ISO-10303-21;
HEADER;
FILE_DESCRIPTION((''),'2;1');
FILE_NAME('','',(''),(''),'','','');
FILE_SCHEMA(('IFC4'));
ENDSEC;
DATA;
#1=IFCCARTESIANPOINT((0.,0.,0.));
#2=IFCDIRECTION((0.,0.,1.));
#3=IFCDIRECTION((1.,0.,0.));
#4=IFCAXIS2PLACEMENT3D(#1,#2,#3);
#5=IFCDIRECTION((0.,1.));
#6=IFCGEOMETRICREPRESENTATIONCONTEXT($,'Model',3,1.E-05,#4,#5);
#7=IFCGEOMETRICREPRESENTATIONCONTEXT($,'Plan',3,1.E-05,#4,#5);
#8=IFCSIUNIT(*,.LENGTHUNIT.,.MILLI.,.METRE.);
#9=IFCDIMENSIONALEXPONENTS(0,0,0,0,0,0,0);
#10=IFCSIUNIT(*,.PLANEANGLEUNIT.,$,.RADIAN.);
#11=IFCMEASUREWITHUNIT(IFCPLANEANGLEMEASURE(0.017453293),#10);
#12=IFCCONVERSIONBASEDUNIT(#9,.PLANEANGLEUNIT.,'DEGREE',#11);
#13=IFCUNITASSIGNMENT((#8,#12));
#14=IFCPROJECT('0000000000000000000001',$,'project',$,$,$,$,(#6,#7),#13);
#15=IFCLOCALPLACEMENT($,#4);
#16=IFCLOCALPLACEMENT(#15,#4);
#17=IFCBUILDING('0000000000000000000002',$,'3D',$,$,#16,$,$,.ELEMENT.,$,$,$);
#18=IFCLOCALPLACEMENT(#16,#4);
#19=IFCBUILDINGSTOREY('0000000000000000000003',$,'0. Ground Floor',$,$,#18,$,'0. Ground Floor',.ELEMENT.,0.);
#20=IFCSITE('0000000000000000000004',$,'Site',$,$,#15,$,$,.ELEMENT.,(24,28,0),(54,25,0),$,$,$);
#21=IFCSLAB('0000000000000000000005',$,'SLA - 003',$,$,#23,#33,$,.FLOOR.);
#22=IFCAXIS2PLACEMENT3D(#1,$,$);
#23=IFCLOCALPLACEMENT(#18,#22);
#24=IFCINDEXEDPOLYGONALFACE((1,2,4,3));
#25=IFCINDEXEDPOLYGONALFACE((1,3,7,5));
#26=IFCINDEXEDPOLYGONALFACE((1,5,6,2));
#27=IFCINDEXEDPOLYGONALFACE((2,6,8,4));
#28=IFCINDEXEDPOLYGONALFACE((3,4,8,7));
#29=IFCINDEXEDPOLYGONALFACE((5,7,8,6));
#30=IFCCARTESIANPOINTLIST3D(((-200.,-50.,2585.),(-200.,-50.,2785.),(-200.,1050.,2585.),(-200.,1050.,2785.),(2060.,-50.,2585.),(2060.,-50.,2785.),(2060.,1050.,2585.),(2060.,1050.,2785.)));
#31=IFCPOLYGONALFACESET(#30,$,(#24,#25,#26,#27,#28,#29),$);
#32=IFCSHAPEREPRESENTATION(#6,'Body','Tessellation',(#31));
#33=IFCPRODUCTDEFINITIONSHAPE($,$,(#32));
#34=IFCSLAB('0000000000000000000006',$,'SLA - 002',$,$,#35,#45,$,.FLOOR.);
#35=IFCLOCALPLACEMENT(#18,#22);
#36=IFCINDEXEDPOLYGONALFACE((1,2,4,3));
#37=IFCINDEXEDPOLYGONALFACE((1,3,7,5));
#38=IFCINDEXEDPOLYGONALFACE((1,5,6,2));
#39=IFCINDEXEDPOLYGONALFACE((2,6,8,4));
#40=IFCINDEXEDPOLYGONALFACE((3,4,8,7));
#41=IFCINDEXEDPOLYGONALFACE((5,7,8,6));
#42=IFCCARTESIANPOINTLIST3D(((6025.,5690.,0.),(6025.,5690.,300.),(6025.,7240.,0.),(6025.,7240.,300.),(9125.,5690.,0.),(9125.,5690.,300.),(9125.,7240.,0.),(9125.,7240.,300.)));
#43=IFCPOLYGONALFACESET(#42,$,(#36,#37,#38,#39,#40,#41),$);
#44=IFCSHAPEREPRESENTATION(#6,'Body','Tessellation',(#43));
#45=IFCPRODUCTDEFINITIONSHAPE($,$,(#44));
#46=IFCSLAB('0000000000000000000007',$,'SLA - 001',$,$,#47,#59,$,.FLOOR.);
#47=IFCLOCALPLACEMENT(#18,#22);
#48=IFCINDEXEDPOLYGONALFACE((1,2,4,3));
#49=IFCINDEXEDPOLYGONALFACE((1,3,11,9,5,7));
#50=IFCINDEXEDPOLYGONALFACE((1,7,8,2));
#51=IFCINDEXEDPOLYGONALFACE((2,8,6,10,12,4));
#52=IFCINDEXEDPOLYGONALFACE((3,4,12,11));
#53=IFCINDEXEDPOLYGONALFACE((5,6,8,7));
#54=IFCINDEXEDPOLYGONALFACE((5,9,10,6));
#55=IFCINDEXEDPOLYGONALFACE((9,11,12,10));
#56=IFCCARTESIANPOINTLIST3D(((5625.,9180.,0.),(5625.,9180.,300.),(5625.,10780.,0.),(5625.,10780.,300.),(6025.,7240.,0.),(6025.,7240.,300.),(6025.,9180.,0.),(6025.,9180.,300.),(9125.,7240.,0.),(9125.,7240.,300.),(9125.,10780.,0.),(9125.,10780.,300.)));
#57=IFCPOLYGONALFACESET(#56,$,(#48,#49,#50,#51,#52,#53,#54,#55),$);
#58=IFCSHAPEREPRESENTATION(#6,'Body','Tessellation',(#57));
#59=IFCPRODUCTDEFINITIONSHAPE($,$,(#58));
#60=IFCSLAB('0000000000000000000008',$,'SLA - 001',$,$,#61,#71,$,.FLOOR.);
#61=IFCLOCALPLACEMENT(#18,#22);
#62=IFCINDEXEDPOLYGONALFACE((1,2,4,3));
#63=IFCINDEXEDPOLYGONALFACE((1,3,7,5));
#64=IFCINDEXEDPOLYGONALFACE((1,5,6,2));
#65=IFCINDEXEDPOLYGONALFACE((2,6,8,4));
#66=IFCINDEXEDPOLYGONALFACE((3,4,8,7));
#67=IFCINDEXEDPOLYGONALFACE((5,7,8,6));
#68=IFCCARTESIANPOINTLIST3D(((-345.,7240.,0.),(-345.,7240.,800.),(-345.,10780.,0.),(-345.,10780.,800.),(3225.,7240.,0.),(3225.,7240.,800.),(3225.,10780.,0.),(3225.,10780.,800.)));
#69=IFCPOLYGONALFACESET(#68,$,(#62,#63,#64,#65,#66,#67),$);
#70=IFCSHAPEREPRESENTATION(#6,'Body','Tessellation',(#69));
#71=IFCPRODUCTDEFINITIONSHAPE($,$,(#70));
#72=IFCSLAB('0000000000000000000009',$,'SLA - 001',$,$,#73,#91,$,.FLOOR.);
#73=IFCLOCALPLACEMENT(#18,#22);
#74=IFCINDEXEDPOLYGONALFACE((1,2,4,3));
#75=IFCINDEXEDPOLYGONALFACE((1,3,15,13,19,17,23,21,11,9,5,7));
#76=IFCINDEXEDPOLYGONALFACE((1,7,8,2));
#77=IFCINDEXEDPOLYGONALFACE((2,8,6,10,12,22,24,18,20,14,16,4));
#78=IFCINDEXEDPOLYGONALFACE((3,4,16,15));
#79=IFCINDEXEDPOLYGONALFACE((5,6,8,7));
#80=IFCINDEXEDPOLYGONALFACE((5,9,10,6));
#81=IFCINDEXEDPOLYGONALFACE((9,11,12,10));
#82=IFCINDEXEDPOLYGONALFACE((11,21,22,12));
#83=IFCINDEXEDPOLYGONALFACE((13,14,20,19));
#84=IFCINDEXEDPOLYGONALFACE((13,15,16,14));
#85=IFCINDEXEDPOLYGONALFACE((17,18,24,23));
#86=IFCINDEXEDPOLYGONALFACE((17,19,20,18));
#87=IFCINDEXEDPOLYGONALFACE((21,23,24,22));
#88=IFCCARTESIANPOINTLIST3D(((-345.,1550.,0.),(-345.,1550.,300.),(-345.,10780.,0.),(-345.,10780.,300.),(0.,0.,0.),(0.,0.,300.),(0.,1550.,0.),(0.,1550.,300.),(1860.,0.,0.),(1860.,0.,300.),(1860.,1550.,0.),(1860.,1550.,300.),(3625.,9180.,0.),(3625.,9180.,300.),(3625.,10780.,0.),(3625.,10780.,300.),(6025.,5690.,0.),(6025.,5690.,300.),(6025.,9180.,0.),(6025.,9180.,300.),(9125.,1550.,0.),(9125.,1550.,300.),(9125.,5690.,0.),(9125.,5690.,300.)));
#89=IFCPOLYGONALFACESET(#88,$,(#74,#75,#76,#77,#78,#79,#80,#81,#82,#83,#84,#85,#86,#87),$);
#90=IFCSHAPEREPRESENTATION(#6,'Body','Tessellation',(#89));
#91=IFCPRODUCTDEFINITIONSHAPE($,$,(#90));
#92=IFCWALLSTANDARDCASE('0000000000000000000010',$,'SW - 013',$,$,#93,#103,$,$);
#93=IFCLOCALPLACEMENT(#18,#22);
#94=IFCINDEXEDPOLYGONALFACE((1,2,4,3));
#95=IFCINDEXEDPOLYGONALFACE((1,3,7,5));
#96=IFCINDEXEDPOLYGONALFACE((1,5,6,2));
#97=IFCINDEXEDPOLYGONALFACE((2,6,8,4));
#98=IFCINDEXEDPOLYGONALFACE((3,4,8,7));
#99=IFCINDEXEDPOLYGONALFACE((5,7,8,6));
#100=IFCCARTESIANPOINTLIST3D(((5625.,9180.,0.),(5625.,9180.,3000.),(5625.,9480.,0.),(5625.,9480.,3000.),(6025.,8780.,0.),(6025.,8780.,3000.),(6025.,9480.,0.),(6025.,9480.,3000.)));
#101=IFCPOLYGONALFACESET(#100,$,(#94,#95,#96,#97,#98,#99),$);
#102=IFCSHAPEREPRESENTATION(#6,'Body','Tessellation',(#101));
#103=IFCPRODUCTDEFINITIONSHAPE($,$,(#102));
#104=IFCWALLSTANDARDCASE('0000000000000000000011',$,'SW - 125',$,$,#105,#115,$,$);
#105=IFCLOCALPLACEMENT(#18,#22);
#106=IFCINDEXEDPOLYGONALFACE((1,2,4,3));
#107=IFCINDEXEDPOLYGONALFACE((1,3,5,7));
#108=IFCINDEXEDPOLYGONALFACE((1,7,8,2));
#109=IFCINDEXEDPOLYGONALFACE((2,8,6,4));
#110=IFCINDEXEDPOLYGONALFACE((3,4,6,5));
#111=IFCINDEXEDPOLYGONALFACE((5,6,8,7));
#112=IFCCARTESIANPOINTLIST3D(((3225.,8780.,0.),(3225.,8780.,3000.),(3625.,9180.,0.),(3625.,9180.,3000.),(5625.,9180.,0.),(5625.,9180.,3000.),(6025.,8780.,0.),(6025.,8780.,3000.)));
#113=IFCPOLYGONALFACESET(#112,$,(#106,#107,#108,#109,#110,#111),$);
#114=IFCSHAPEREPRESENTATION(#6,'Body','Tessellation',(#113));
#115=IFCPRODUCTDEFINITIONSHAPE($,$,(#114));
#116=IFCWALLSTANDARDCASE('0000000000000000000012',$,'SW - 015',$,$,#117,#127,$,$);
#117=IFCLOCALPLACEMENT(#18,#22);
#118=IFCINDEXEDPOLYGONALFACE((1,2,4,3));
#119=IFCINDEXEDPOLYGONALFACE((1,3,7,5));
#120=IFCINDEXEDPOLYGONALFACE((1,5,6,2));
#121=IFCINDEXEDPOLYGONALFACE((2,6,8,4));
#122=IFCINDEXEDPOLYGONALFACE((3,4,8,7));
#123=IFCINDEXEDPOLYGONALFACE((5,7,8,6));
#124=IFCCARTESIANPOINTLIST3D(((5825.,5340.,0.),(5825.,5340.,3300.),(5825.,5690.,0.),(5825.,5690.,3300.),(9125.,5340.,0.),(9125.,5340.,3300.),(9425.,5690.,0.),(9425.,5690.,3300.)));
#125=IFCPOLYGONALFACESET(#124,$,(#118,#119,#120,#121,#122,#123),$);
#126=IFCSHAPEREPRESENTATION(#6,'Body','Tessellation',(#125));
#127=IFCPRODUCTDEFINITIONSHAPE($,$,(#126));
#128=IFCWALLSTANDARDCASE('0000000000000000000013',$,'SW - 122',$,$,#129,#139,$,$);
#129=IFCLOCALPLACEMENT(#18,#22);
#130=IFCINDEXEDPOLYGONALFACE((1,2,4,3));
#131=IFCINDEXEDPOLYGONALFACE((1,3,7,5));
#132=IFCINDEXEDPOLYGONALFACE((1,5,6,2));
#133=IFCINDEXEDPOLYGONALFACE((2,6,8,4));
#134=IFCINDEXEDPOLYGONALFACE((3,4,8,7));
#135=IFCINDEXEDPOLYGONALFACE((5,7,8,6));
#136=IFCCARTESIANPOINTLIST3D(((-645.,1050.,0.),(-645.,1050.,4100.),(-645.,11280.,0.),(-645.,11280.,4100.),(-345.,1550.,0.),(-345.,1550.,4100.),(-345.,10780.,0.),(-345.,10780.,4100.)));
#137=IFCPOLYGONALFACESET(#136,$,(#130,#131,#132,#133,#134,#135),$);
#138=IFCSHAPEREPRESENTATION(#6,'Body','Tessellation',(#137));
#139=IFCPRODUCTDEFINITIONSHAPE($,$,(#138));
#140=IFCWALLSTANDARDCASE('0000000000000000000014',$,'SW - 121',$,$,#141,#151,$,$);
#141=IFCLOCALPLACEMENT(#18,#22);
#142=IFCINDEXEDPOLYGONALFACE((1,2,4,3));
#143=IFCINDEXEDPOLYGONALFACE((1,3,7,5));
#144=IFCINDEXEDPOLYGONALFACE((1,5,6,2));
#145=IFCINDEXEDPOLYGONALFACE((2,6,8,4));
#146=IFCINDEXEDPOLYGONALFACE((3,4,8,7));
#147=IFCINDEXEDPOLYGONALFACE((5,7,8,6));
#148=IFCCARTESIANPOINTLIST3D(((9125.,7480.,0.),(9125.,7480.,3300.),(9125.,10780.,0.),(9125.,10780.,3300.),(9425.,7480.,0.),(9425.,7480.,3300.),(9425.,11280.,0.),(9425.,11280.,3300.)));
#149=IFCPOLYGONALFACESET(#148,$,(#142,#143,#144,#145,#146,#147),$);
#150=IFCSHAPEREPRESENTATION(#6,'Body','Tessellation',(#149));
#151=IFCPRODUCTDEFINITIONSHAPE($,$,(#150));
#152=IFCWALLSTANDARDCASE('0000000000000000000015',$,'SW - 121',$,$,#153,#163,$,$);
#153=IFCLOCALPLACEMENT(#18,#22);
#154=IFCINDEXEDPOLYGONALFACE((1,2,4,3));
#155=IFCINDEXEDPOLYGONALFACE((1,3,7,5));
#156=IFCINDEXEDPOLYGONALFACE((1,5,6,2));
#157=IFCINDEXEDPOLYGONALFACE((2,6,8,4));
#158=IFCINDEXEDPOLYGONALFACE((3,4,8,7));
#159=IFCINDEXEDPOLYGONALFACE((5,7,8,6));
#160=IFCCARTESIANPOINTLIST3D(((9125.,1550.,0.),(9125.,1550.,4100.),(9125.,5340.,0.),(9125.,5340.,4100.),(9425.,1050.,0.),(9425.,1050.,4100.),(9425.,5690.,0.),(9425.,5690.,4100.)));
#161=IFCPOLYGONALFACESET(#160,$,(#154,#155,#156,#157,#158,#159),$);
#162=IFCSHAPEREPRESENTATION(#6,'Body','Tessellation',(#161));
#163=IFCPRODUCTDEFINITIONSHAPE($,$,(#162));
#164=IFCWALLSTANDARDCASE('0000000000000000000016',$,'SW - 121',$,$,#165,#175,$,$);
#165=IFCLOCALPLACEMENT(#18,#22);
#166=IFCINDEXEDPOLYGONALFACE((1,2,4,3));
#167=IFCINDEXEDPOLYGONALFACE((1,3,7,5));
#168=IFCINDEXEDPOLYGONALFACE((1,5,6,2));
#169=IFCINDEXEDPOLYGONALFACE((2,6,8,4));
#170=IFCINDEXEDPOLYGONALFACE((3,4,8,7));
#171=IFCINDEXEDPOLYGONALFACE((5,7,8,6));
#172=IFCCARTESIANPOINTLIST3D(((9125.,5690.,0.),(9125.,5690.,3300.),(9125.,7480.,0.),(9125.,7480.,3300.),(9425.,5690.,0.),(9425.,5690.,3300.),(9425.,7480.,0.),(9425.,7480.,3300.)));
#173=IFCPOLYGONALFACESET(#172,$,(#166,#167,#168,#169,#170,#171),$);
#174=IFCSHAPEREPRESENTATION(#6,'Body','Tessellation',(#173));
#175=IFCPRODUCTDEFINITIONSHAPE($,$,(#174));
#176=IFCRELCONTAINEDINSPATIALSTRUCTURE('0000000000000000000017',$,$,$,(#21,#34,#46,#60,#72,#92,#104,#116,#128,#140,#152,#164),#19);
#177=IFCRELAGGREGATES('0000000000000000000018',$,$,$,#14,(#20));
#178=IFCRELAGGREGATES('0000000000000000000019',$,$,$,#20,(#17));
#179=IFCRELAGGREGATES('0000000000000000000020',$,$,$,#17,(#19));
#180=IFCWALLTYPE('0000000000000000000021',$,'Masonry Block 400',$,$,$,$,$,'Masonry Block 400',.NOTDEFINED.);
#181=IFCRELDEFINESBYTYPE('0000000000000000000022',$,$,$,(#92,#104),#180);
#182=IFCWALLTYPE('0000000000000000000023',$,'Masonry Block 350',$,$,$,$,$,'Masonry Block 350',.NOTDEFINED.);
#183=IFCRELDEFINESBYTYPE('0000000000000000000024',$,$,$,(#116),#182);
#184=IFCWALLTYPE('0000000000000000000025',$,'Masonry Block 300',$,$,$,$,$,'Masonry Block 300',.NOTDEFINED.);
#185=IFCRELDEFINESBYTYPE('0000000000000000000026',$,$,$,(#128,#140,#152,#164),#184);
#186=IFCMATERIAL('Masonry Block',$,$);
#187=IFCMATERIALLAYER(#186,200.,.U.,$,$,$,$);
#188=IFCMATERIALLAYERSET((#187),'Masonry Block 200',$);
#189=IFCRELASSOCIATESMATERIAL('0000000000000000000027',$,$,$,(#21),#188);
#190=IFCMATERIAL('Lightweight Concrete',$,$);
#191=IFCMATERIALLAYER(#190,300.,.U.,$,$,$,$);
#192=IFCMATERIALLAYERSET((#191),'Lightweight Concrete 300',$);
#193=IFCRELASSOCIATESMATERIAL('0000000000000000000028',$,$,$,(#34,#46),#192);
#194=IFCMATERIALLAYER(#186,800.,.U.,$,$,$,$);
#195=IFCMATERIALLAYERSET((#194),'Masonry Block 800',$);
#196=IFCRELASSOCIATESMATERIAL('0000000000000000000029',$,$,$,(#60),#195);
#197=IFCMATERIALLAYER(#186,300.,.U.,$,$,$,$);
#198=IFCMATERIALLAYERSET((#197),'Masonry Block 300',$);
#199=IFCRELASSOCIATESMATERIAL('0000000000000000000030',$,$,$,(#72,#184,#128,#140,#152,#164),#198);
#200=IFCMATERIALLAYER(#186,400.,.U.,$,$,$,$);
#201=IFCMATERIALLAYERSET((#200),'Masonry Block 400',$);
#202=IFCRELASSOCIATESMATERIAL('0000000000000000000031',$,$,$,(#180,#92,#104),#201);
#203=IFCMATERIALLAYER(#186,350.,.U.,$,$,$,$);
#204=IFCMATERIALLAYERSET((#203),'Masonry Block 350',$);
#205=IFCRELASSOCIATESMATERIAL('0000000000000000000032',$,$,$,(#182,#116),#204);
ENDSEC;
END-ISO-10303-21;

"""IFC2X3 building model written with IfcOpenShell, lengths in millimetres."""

from ifc_helpers import new_model, entity, si_unit, converted_unit, direction, frame, origin_with_axes, place, context, project, spatial, polyline, outline, extrude, material, layer, layer_set, layer_usage, type_object, element, save


model = new_model("IFC2X3")

# Units and contexts
model_context = context("Model", 3, precision=1e-05, world=origin_with_axes(), true_north=direction((0.0, 1.0)))
plan_context = context("Plan", 3, precision=1e-05, world=origin_with_axes(), true_north=direction((0.0, 1.0)))
ifc_project = project(units=[si_unit("LENGTHUNIT", "METRE", prefix="MILLI"), converted_unit("PLANEANGLEUNIT", "DEGREE", entity("IfcPlaneAngleMeasure", 0.017453293), si_unit("PLANEANGLEUNIT", "RADIAN"), dimensions=[0, 0, 0, 0, 0, 0, 0])], contexts=[model_context, plan_context])

# Site, building, storey
site_placement = place(None, origin_with_axes())
site = spatial("IfcSite", under=ifc_project, at=site_placement, Name="Site", CompositionType="ELEMENT", RefLatitude=(24, 28, 0), RefLongitude=(54, 25, 0))
building_placement = place(site_placement, origin_with_axes())
building = spatial("IfcBuilding", under=site, at=building_placement, Name="3D", CompositionType="ELEMENT")
storey_placement = place(building_placement, origin_with_axes())
storey = spatial("IfcBuildingStorey", under=building, at=storey_placement, Name="0. Ground Floor", LongName="0. Ground Floor", CompositionType="ELEMENT", Elevation=0.0)

# Slabs
ifc_material_1 = material(Name="Masonry Block")
ifc_layer_1 = layer(ifc_material_1, 200.0, ventilated="UNKNOWN")
ifc_layer_set_1 = layer_set([ifc_layer_1], Name="Masonry Block 200")
ifc_layer_usage_1 = layer_usage(ifc_layer_set_1, "AXIS3", "NEGATIVE", 200.0)
slab_1_placement = place(storey_placement, frame((-200.0, 1050.0, 2585.0), z_axis=(0.0, 0.0, 1.0), x_axis=(1.0, 0.0, 0.0)))
element("IfcSlab", 1, at=slab_1_placement, inside=storey, material=ifc_layer_usage_1, Name="SLA - 003", PredefinedType="FLOOR", context=model_context, shape_type="SweptSolid", body=[
    extrude(outline(polyline([(0.0, 0.0), (2260.0, 0.0), (2260.0, -1100.0), (0.0, -1100.0), (0.0, 0.0)])), origin_with_axes(), (0.0, 0.0, 1.0), 200.0),
])
ifc_material_2 = material(Name="Lightweight Concrete")
ifc_layer_2 = layer(ifc_material_2, 300.0, ventilated="UNKNOWN")
ifc_layer_set_2 = layer_set([ifc_layer_2], Name="Lightweight Concrete 300")
ifc_layer_usage_2 = layer_usage(ifc_layer_set_2, "AXIS3", "NEGATIVE", 300.0)
slab_2_placement = place(storey_placement, frame((9125.0, 7240.0, 0.0), z_axis=(0.0, 0.0, 1.0), x_axis=(-1.0, 0.0, 0.0)))
element("IfcSlab", 2, at=slab_2_placement, inside=storey, material=ifc_layer_usage_2, Name="SLA - 002", PredefinedType="FLOOR", context=model_context, shape_type="SweptSolid", body=[
    extrude(outline(polyline([(0.0, 0.0), (3100.0, 0.0), (3100.0, 1550.0), (0.0, 1550.0), (0.0, 0.0)])), origin_with_axes(), (0.0, 0.0, 1.0), 300.0),
])
ifc_layer_usage_3 = layer_usage(ifc_layer_set_2, "AXIS3", "NEGATIVE", 300.0)
slab_3_placement = place(storey_placement, frame((5625.0, 9180.0, 0.0), z_axis=(0.0, 0.0, 1.0), x_axis=(1.0, 0.0, 0.0)))
element("IfcSlab", 3, at=slab_3_placement, inside=storey, material=ifc_layer_usage_3, Name="SLA - 001", PredefinedType="FLOOR", context=model_context, shape_type="SweptSolid", body=[
    extrude(outline(polyline([(0.0, 0.0), (400.0, 0.0), (400.0, -1940.0), (3500.0, -1940.0), (3500.0, 1600.0), (0.0, 1600.0), (0.0, 0.0)])), origin_with_axes(), (0.0, 0.0, 1.0), 300.0),
])
ifc_layer_3 = layer(ifc_material_1, 800.0, ventilated="UNKNOWN")
ifc_layer_set_3 = layer_set([ifc_layer_3], Name="Masonry Block 800")
ifc_layer_usage_4 = layer_usage(ifc_layer_set_3, "AXIS3", "NEGATIVE", 800.0)
slab_4_placement = place(storey_placement, frame((-345.0, 10780.0, 0.0), z_axis=(0.0, 0.0, 1.0), x_axis=(1.0, 0.0, 0.0)))
element("IfcSlab", 4, at=slab_4_placement, inside=storey, material=ifc_layer_usage_4, Name="SLA - 001", PredefinedType="FLOOR", context=model_context, shape_type="SweptSolid", body=[
    extrude(outline(polyline([(0.0, 0.0), (3570.0, 0.0), (3570.0, -3540.0), (0.0, -3540.0), (0.0, 0.0)])), origin_with_axes(), (0.0, 0.0, 1.0), 800.0),
])
ifc_layer_4 = layer(ifc_material_1, 300.0, ventilated="UNKNOWN")
ifc_layer_set_4 = layer_set([ifc_layer_4], Name="Masonry Block 300")
ifc_layer_usage_5 = layer_usage(ifc_layer_set_4, "AXIS3", "NEGATIVE", 300.0)
slab_5_placement = place(storey_placement, frame((-345.0, 10780.0, 0.0), z_axis=(0.0, 0.0, 1.0), x_axis=(0.0, -1.0, 0.0)))
element("IfcSlab", 5, at=slab_5_placement, inside=storey, material=ifc_layer_usage_5, Name="SLA - 001", PredefinedType="FLOOR", context=model_context, shape_type="SweptSolid", body=[
    extrude(outline(polyline([(0.0, 0.0), (9230.0, 0.0), (9230.0, 345.0), (10780.0, 345.0), (10780.0, 2205.0), (9230.0, 2205.0), (9230.0, 9470.0), (5090.0, 9470.0), (5090.0, 6370.0), (1600.0, 6370.0), (1600.0, 3970.0), (0.0, 3970.0), (0.0, 0.0)])), origin_with_axes(), (0.0, 0.0, 1.0), 300.0),
])

# Walls
ifc_layer_5 = layer(ifc_material_1, 400.0, ventilated="UNKNOWN")
ifc_layer_set_5 = layer_set([ifc_layer_5], Name="Masonry Block 400")
wall_type_1 = type_object("IfcWallType", Name="Masonry Block 400", ElementType="Masonry Block 400", PredefinedType="NOTDEFINED", material=ifc_layer_set_5)
ifc_layer_usage_6 = layer_usage(ifc_layer_set_5, "AXIS2", "POSITIVE", 0.0)
wall_1_placement = place(storey_placement, frame((6025.0, 8780.0, 0.0), z_axis=(0.0, 0.0, 1.0), x_axis=(0.0, 1.0, 0.0)))
element("IfcWallStandardCase", 6, at=wall_1_placement, inside=storey, type_object=wall_type_1, material=ifc_layer_usage_6, Name="SW - 013", context=model_context, shape_type="SweptSolid", body=[
    extrude(outline(polyline([(0.0, 0.0), (700.0, 0.0), (700.0, 400.0), (400.0, 400.0), (0.0, 0.0)])), origin_with_axes(), (0.0, 0.0, 1.0), 3000.0),
])
ifc_layer_usage_7 = layer_usage(ifc_layer_set_5, "AXIS2", "POSITIVE", 0.0)
wall_2_placement = place(storey_placement, frame((3225.0, 8780.0, 0.0), z_axis=(0.0, 0.0, 1.0), x_axis=(1.0, 0.0, 0.0)))
element("IfcWallStandardCase", 7, at=wall_2_placement, inside=storey, type_object=wall_type_1, material=ifc_layer_usage_7, Name="SW - 125", context=model_context, shape_type="SweptSolid", body=[
    extrude(outline(polyline([(0.0, 0.0), (2800.0, 0.0), (2400.0, 400.0), (400.0, 400.0), (0.0, 0.0)])), origin_with_axes(), (0.0, 0.0, 1.0), 3000.0),
])
ifc_layer_6 = layer(ifc_material_1, 350.0, ventilated="UNKNOWN")
ifc_layer_set_6 = layer_set([ifc_layer_6], Name="Masonry Block 350")
ifc_layer_usage_8 = layer_usage(ifc_layer_set_6, "AXIS2", "POSITIVE", 0.0)
wall_type_2 = type_object("IfcWallType", Name="Masonry Block 350", ElementType="Masonry Block 350", PredefinedType="NOTDEFINED", material=ifc_layer_set_6)
wall_3_placement = place(storey_placement, frame((5825.0, 5340.0, 0.0), z_axis=(0.0, 0.0, 1.0), x_axis=(1.0, 0.0, 0.0)))
element("IfcWallStandardCase", 8, at=wall_3_placement, inside=storey, type_object=wall_type_2, material=ifc_layer_usage_8, Name="SW - 015", context=model_context, shape_type="SweptSolid", body=[
    extrude(outline(polyline([(0.0, 0.0), (3300.0, 0.0), (3600.0, 350.0), (0.0, 350.0), (0.0, 0.0)])), origin_with_axes(), (0.0, 0.0, 1.0), 3300.0),
])
ifc_layer_usage_9 = layer_usage(ifc_layer_set_4, "AXIS2", "POSITIVE", 0.0)
wall_type_3 = type_object("IfcWallType", Name="Masonry Block 300", ElementType="Masonry Block 300", PredefinedType="NOTDEFINED", material=ifc_layer_set_4)
wall_4_placement = place(storey_placement, frame((-645.0, 11280.0, 0.0), z_axis=(0.0, 0.0, 1.0), x_axis=(0.0, -1.0, 0.0)))
element("IfcWallStandardCase", 9, at=wall_4_placement, inside=storey, type_object=wall_type_3, material=ifc_layer_usage_9, Name="SW - 122", context=model_context, shape_type="SweptSolid", body=[
    extrude(outline(polyline([(0.0, 0.0), (10230.0, 0.0), (9730.0, 300.0), (500.0, 300.0), (0.0, 0.0)])), origin_with_axes(), (0.0, 0.0, 1.0), 4100.0),
])
ifc_layer_usage_10 = layer_usage(ifc_layer_set_4, "AXIS2", "NEGATIVE", 0.0)
wall_5_placement = place(storey_placement, frame((9425.0, 11280.0, 0.0), z_axis=(0.0, 0.0, 1.0), x_axis=(0.0, -1.0, 0.0)))
element("IfcWallStandardCase", 10, at=wall_5_placement, inside=storey, type_object=wall_type_3, material=ifc_layer_usage_10, Name="SW - 121", context=model_context, shape_type="SweptSolid", body=[
    extrude(outline(polyline([(500.0, -300.0), (3800.0, -300.0), (3800.0, 0.0), (0.0, 0.0), (500.0, -300.0)])), origin_with_axes(), (0.0, 0.0, 1.0), 3300.0),
])
ifc_layer_usage_11 = layer_usage(ifc_layer_set_4, "AXIS2", "NEGATIVE", 0.0)
wall_6_placement = place(storey_placement, frame((9425.0, 5340.0, 0.0), z_axis=(0.0, 0.0, 1.0), x_axis=(0.0, -1.0, 0.0)))
element("IfcWallStandardCase", 11, at=wall_6_placement, inside=storey, type_object=wall_type_3, material=ifc_layer_usage_11, Name="SW - 121", context=model_context, shape_type="SweptSolid", body=[
    extrude(outline(polyline([(0.0, -300.0), (3790.0, -300.0), (4290.0, 0.0), (-350.0, 0.0), (0.0, -300.0)])), origin_with_axes(), (0.0, 0.0, 1.0), 4100.0),
])
ifc_layer_usage_12 = layer_usage(ifc_layer_set_4, "AXIS2", "NEGATIVE", 0.0)
wall_7_placement = place(storey_placement, frame((9425.0, 7480.0, 0.0), z_axis=(0.0, 0.0, 1.0), x_axis=(0.0, -1.0, 0.0)))
element("IfcWallStandardCase", 12, at=wall_7_placement, inside=storey, type_object=wall_type_3, material=ifc_layer_usage_12, Name="SW - 121", context=model_context, shape_type="SweptSolid", body=[
    extrude(outline(polyline([(0.0, -300.0), (1790.0, -300.0), (1790.0, 0.0), (0.0, 0.0), (0.0, -300.0)])), origin_with_axes(), (0.0, 0.0, 1.0), 3300.0),
])

save(model, "model.ifc")
